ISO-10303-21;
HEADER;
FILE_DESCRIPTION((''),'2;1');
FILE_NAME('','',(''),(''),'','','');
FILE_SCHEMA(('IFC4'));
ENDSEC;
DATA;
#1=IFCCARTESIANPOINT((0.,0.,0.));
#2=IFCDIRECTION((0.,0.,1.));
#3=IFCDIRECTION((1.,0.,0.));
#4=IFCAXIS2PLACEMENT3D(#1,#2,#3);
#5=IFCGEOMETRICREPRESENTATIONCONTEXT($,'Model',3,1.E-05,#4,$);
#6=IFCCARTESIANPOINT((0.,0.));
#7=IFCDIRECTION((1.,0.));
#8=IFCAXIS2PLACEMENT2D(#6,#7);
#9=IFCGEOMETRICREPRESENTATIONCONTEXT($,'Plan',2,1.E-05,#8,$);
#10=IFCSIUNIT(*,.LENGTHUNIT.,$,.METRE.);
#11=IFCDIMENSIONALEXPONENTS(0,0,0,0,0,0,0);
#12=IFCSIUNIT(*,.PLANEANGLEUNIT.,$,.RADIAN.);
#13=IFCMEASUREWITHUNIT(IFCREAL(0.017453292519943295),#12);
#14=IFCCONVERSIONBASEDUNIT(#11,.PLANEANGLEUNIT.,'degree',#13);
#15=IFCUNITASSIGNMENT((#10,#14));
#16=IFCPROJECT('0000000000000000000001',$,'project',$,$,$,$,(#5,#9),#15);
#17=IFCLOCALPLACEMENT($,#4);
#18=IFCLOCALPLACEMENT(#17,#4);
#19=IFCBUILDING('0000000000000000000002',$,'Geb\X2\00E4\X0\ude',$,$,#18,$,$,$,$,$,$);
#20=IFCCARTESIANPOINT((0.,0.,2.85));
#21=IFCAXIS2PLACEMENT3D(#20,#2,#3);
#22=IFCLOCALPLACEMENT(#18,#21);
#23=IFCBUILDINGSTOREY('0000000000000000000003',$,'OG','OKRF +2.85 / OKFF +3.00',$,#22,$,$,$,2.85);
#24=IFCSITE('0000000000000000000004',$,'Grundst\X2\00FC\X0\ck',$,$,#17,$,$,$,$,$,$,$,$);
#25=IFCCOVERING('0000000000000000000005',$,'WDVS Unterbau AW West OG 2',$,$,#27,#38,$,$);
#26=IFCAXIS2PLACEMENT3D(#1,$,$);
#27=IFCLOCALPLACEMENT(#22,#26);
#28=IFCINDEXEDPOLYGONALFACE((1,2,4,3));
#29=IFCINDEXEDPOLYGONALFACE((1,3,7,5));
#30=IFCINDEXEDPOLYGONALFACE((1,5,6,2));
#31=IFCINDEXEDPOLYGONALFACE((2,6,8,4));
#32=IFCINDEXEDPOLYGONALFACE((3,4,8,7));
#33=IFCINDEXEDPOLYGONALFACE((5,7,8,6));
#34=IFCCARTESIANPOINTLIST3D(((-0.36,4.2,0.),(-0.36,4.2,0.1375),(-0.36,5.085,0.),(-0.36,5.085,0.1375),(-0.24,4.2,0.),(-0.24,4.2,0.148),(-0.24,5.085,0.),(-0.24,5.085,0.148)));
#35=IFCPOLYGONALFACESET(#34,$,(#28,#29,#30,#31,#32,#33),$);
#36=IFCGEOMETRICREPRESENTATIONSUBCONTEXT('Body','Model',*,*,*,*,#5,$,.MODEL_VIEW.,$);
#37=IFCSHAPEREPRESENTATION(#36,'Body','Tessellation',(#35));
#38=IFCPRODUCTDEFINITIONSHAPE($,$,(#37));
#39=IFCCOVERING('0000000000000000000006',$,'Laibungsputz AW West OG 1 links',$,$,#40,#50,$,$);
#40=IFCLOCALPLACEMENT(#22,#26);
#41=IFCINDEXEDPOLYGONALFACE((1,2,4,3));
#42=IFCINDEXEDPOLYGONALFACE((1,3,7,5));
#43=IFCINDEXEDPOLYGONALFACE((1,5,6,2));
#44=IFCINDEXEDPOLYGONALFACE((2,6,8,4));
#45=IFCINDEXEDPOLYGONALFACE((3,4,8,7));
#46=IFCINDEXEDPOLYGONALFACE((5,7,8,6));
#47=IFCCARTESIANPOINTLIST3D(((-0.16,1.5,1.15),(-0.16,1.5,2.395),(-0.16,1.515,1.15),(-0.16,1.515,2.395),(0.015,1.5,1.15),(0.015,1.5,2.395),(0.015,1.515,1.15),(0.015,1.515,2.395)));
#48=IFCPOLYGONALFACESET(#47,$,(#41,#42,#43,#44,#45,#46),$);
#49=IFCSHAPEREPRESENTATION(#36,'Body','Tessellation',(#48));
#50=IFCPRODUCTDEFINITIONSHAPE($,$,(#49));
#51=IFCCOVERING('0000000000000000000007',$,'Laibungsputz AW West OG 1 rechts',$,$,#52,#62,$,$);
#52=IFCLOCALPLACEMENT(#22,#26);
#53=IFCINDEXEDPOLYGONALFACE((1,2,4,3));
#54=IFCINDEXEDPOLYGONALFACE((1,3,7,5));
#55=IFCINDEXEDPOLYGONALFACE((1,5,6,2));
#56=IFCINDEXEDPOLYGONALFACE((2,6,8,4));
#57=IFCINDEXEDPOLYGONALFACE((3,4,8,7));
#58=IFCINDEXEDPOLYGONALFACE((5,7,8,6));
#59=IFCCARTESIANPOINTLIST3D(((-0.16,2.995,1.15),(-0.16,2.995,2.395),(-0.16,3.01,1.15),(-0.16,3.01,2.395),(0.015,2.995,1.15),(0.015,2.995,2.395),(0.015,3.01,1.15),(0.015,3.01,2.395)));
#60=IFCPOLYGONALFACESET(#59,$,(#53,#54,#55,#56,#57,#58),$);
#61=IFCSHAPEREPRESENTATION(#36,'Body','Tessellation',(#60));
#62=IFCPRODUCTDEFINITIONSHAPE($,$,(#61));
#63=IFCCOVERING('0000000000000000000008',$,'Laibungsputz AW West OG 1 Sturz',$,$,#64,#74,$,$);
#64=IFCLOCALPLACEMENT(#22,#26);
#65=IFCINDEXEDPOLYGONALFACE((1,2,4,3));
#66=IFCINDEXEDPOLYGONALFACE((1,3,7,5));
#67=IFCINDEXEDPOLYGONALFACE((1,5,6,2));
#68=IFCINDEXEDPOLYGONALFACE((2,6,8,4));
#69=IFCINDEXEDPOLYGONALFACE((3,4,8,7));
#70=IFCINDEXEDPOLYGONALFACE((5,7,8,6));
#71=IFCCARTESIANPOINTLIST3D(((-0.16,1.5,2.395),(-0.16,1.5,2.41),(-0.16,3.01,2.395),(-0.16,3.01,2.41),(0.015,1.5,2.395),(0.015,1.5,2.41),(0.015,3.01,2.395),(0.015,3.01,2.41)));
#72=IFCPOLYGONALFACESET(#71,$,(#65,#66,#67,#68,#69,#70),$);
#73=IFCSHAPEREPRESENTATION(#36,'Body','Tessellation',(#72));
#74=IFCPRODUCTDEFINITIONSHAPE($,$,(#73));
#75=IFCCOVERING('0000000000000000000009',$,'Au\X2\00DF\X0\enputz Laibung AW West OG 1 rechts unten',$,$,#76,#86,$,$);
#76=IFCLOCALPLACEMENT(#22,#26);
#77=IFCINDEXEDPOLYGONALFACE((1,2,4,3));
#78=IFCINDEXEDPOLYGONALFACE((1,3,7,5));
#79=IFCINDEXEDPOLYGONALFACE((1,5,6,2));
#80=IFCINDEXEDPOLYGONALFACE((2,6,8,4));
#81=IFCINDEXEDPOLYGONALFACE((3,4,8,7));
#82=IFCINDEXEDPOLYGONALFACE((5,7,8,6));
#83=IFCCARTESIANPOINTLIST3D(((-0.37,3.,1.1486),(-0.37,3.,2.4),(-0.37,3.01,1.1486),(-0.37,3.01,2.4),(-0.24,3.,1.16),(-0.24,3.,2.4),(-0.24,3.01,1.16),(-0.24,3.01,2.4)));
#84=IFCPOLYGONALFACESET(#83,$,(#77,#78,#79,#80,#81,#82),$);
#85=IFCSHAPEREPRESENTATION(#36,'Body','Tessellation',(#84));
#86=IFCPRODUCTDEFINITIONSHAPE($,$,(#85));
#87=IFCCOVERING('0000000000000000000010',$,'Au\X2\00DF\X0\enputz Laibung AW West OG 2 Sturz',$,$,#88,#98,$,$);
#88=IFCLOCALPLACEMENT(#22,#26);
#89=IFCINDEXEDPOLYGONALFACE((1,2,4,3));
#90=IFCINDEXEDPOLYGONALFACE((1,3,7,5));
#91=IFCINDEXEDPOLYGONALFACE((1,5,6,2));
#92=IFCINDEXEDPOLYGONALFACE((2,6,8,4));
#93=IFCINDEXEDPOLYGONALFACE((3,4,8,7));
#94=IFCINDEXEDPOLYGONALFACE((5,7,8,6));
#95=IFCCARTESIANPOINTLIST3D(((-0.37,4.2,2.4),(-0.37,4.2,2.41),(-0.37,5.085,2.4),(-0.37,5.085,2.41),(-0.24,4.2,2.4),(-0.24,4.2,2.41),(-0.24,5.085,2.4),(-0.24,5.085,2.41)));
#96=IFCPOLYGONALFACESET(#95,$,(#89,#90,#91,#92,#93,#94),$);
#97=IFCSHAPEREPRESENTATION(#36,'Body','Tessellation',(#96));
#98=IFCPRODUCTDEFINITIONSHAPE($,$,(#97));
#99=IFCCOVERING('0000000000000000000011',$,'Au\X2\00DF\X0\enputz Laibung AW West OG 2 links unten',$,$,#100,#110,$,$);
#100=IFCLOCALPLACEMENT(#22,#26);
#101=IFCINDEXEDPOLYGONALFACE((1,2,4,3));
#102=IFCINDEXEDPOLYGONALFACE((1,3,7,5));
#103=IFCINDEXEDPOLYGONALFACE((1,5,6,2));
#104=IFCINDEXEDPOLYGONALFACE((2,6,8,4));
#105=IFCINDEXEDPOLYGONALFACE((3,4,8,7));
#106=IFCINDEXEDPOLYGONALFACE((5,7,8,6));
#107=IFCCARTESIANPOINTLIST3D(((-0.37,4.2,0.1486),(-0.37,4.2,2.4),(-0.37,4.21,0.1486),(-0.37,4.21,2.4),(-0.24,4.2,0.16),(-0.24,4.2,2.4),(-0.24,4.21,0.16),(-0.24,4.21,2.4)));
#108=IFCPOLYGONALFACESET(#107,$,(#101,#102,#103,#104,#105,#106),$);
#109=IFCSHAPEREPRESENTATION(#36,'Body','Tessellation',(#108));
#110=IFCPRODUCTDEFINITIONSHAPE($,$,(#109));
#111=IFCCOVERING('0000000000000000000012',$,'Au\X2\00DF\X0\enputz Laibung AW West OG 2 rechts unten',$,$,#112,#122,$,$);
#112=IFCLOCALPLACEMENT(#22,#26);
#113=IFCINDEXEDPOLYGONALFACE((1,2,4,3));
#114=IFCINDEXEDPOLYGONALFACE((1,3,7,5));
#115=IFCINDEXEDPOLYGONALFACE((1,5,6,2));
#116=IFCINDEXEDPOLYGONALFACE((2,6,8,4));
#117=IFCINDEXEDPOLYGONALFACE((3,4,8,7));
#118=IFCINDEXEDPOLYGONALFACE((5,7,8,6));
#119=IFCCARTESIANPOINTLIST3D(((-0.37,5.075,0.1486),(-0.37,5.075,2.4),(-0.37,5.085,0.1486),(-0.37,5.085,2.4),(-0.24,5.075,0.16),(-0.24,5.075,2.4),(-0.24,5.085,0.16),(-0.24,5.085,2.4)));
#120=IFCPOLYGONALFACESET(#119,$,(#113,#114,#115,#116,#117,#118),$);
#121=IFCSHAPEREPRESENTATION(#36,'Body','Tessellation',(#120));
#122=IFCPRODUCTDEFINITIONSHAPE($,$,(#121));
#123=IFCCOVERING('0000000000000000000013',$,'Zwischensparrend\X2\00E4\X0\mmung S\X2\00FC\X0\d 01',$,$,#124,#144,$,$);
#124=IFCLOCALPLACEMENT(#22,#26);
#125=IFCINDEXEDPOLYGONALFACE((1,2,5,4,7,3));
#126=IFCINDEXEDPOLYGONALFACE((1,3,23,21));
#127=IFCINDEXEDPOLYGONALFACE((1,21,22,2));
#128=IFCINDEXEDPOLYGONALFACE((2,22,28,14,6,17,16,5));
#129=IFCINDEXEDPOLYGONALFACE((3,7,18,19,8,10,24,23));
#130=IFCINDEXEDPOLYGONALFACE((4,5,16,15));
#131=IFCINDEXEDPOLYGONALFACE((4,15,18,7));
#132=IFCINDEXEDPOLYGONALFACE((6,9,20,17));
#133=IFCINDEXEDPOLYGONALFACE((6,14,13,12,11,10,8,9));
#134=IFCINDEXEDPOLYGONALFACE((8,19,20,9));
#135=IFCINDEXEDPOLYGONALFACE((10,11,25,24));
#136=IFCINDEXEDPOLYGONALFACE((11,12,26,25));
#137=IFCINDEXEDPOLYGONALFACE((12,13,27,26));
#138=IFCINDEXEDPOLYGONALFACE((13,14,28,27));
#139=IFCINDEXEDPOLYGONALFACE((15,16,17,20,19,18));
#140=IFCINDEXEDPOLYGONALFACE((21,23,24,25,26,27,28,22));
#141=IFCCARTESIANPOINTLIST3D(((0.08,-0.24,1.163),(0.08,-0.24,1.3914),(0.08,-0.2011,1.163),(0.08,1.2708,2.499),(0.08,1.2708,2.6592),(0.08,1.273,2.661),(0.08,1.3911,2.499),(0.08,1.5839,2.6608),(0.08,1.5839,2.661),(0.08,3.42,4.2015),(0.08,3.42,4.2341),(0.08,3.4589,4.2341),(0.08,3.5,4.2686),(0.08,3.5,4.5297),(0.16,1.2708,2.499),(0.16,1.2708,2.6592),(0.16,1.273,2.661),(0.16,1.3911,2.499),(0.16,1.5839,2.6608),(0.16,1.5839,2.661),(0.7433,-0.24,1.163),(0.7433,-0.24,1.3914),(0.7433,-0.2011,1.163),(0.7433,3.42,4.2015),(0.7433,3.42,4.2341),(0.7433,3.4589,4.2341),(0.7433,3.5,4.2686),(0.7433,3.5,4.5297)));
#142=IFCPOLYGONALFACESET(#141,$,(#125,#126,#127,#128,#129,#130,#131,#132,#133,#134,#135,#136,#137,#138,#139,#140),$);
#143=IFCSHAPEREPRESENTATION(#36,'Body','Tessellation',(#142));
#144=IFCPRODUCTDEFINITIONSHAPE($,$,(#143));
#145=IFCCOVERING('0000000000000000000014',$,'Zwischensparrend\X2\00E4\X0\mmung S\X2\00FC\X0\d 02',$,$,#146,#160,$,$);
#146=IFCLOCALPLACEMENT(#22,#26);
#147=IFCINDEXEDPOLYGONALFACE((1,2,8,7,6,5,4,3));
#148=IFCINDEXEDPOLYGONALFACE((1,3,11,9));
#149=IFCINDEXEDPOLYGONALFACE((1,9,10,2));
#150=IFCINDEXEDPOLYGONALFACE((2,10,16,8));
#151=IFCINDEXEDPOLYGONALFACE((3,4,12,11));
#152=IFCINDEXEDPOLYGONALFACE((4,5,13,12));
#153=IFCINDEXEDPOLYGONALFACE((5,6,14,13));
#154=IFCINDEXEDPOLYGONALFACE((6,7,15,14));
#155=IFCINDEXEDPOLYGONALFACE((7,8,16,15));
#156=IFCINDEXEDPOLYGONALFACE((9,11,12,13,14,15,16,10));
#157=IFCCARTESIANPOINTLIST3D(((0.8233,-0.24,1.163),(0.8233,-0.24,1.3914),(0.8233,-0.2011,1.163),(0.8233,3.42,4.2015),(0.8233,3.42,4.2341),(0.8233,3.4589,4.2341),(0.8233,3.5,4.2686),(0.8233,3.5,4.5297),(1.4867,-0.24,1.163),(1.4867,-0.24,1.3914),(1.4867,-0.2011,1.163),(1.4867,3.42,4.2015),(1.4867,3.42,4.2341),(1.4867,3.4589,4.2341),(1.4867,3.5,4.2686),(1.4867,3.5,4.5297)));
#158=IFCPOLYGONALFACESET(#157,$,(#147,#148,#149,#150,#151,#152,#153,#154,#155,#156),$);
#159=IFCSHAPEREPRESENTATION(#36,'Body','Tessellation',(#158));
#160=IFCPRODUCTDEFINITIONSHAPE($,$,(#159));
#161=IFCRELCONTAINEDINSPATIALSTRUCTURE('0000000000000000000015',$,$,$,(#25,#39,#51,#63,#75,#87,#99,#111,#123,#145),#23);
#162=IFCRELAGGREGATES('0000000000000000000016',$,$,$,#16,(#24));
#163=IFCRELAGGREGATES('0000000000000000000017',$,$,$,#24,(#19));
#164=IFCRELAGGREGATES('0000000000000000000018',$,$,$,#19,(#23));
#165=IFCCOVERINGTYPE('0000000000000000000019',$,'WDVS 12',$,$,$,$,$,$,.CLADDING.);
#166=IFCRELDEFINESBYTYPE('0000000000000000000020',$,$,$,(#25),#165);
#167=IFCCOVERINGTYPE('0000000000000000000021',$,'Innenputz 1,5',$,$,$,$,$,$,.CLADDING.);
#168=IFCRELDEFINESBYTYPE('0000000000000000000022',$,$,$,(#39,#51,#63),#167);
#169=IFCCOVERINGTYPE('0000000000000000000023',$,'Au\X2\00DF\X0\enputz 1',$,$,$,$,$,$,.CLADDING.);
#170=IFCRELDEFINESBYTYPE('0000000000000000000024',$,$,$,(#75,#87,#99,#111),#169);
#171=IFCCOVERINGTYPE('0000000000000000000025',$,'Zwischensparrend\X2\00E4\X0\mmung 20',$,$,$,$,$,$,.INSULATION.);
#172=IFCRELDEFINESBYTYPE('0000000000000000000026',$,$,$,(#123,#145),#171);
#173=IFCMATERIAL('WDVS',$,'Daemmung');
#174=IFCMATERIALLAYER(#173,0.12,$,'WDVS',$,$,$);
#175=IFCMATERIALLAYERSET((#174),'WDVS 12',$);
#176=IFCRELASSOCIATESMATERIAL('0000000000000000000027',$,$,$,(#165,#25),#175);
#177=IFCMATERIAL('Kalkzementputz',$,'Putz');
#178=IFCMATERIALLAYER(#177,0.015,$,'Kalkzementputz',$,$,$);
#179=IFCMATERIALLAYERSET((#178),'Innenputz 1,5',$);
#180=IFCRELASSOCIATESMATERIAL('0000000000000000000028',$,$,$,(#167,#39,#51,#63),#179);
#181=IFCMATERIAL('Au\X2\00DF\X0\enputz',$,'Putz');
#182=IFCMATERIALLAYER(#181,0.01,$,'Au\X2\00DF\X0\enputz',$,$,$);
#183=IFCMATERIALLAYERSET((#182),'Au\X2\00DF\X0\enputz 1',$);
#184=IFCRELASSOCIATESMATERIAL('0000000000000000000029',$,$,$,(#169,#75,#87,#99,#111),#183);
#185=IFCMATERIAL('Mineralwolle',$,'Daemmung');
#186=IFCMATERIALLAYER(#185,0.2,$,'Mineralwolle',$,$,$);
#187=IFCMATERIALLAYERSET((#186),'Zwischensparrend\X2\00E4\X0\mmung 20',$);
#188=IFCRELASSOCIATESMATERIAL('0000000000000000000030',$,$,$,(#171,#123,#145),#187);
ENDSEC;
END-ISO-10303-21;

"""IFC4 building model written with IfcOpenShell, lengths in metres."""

from ifc_helpers import new_model, entity, si_unit, converted_unit, frame, origin_with_axes, origin_2d_with_axis, place, context, subcontext, project, spatial, polyline, outline, extrude, material, layer, layer_set, layer_usage, type_object, element, save


model = new_model("IFC4")

# Units and contexts
model_context = context("Model", 3, precision=1e-05, world=origin_with_axes())
plan_context = context("Plan", 2, precision=1e-05, world=origin_2d_with_axis())
body_context = subcontext(model_context, "Body", "Model", "MODEL_VIEW")
ifc_project = project(units=[si_unit("LENGTHUNIT", "METRE"), converted_unit("PLANEANGLEUNIT", "degree", entity("IfcReal", 0.017453292519943295), si_unit("PLANEANGLEUNIT", "RADIAN"), dimensions=[0, 0, 0, 0, 0, 0, 0])], contexts=[model_context, plan_context])

# Site, building, storey
site_placement = place(None, origin_with_axes())
site = spatial("IfcSite", under=ifc_project, at=site_placement, Name="Grundstück")
building_placement = place(site_placement, origin_with_axes())
building = spatial("IfcBuilding", under=site, at=building_placement, Name="Gebäude")
storey_placement = place(building_placement, frame((0.0, 0.0, 2.85), z_axis=(0.0, 0.0, 1.0), x_axis=(1.0, 0.0, 0.0)))
storey = spatial("IfcBuildingStorey", under=building, at=storey_placement, Name="OG", Description="OKRF +2.85 / OKFF +3.00", Elevation=2.85)

# Coverings
ifc_material_1 = material(Name="WDVS", Category="Daemmung")
ifc_layer_1 = layer(ifc_material_1, 0.12, Name="WDVS")
ifc_layer_set_1 = layer_set([ifc_layer_1], Name="WDVS 12")
ifc_layer_usage_1 = layer_usage(ifc_layer_set_1, "AXIS2", "POSITIVE", 0.24)
covering_type_1 = type_object("IfcCoveringType", Name="WDVS 12", PredefinedType="CLADDING", material=ifc_layer_set_1)
covering_1_placement = place(storey_placement, frame((0.0, 0.0, 0.0), z_axis=(0.0, 0.0, 1.0), x_axis=(0.0, 1.0, 0.0)))
element("IfcCovering", 1, at=covering_1_placement, inside=storey, type_object=covering_type_1, material=ifc_layer_usage_1, Name="WDVS Unterbau AW West OG 2", context=body_context, shape_type="SweptSolid", body=[
    extrude(outline(polyline([(0.24, 0.0), (0.36, 0.0), (0.36, 0.1375), (0.24, 0.148), (0.24, 0.0)])), frame((4.2, 0.0, 0.0), z_axis=(1.0, 0.0, 0.0), x_axis=(0.0, 1.0, 0.0)), (0.0, 0.0, 1.0), 0.885),
])
ifc_material_2 = material(Name="Kalkzementputz", Category="Putz")
ifc_layer_2 = layer(ifc_material_2, 0.015, Name="Kalkzementputz")
ifc_layer_set_2 = layer_set([ifc_layer_2], Name="Innenputz 1,5")
ifc_layer_usage_2 = layer_usage(ifc_layer_set_2, "AXIS1", "POSITIVE", 1.5)
covering_type_2 = type_object("IfcCoveringType", Name="Innenputz 1,5", PredefinedType="CLADDING", material=ifc_layer_set_2)
covering_2_placement = place(storey_placement, frame((0.0, 0.0, 0.0), z_axis=(0.0, 0.0, 1.0), x_axis=(0.0, 1.0, 0.0)))
element("IfcCovering", 2, at=covering_2_placement, inside=storey, type_object=covering_type_2, material=ifc_layer_usage_2, Name="Laibungsputz AW West OG 1 links", context=body_context, shape_type="SweptSolid", body=[
    extrude(outline(polyline([(-0.015, 1.15), (0.16, 1.15), (0.16, 2.395), (-0.015, 2.395), (-0.015, 1.15)])), frame((1.5, 0.0, 0.0), z_axis=(1.0, 0.0, 0.0), x_axis=(0.0, 1.0, 0.0)), (0.0, 0.0, 1.0), 0.015),
])
ifc_layer_usage_3 = layer_usage(ifc_layer_set_2, "AXIS1", "POSITIVE", 2.995)
covering_3_placement = place(storey_placement, frame((0.0, 0.0, 0.0), z_axis=(0.0, 0.0, 1.0), x_axis=(0.0, 1.0, 0.0)))
element("IfcCovering", 3, at=covering_3_placement, inside=storey, type_object=covering_type_2, material=ifc_layer_usage_3, Name="Laibungsputz AW West OG 1 rechts", context=body_context, shape_type="SweptSolid", body=[
    extrude(outline(polyline([(-0.015, 1.15), (0.16, 1.15), (0.16, 2.395), (-0.015, 2.395), (-0.015, 1.15)])), frame((2.995, 0.0, 0.0), z_axis=(1.0, 0.0, 0.0), x_axis=(0.0, 1.0, 0.0)), (0.0, 0.0, 1.0), 0.015),
])
ifc_layer_usage_4 = layer_usage(ifc_layer_set_2, "AXIS3", "POSITIVE", 2.395)
covering_4_placement = place(storey_placement, frame((0.0, 0.0, 0.0), z_axis=(0.0, 0.0, 1.0), x_axis=(0.0, 1.0, 0.0)))
element("IfcCovering", 4, at=covering_4_placement, inside=storey, type_object=covering_type_2, material=ifc_layer_usage_4, Name="Laibungsputz AW West OG 1 Sturz", context=body_context, shape_type="SweptSolid", body=[
    extrude(outline(polyline([(-0.015, 2.395), (0.16, 2.395), (0.16, 2.41), (-0.015, 2.41), (-0.015, 2.395)])), frame((1.5, 0.0, 0.0), z_axis=(1.0, 0.0, 0.0), x_axis=(0.0, 1.0, 0.0)), (0.0, 0.0, 1.0), 1.51),
])
ifc_material_3 = material(Name="Außenputz", Category="Putz")
ifc_layer_3 = layer(ifc_material_3, 0.01, Name="Außenputz")
ifc_layer_set_3 = layer_set([ifc_layer_3], Name="Außenputz 1")
ifc_layer_usage_5 = layer_usage(ifc_layer_set_3, "AXIS1", "POSITIVE", 3.0)
covering_type_3 = type_object("IfcCoveringType", Name="Außenputz 1", PredefinedType="CLADDING", material=ifc_layer_set_3)
covering_5_placement = place(storey_placement, frame((0.0, 0.0, 0.0), z_axis=(0.0, 0.0, 1.0), x_axis=(0.0, 1.0, 0.0)))
element("IfcCovering", 5, at=covering_5_placement, inside=storey, type_object=covering_type_3, material=ifc_layer_usage_5, Name="Außenputz Laibung AW West OG 1 rechts unten", context=body_context, shape_type="SweptSolid", body=[
    extrude(outline(polyline([(0.24, 1.16), (0.37, 1.1486), (0.37, 2.4), (0.24, 2.4), (0.24, 1.16)])), frame((3.0, 0.0, 0.0), z_axis=(1.0, 0.0, 0.0), x_axis=(0.0, 1.0, 0.0)), (0.0, 0.0, 1.0), 0.01),
])
ifc_layer_usage_6 = layer_usage(ifc_layer_set_3, "AXIS3", "POSITIVE", 2.4)
covering_6_placement = place(storey_placement, frame((0.0, 0.0, 0.0), z_axis=(0.0, 0.0, 1.0), x_axis=(0.0, 1.0, 0.0)))
element("IfcCovering", 6, at=covering_6_placement, inside=storey, type_object=covering_type_3, material=ifc_layer_usage_6, Name="Außenputz Laibung AW West OG 2 Sturz", context=body_context, shape_type="SweptSolid", body=[
    extrude(outline(polyline([(0.24, 2.4), (0.37, 2.4), (0.37, 2.41), (0.24, 2.41), (0.24, 2.4)])), frame((4.2, 0.0, 0.0), z_axis=(1.0, 0.0, 0.0), x_axis=(0.0, 1.0, 0.0)), (0.0, 0.0, 1.0), 0.885),
])
ifc_layer_usage_7 = layer_usage(ifc_layer_set_3, "AXIS1", "POSITIVE", 4.2)
covering_7_placement = place(storey_placement, frame((0.0, 0.0, 0.0), z_axis=(0.0, 0.0, 1.0), x_axis=(0.0, 1.0, 0.0)))
element("IfcCovering", 7, at=covering_7_placement, inside=storey, type_object=covering_type_3, material=ifc_layer_usage_7, Name="Außenputz Laibung AW West OG 2 links unten", context=body_context, shape_type="SweptSolid", body=[
    extrude(outline(polyline([(0.24, 0.16), (0.37, 0.1486), (0.37, 2.4), (0.24, 2.4), (0.24, 0.16)])), frame((4.2, 0.0, 0.0), z_axis=(1.0, 0.0, 0.0), x_axis=(0.0, 1.0, 0.0)), (0.0, 0.0, 1.0), 0.01),
])
ifc_layer_usage_8 = layer_usage(ifc_layer_set_3, "AXIS1", "POSITIVE", 5.075)
covering_8_placement = place(storey_placement, frame((0.0, 0.0, 0.0), z_axis=(0.0, 0.0, 1.0), x_axis=(0.0, 1.0, 0.0)))
element("IfcCovering", 8, at=covering_8_placement, inside=storey, type_object=covering_type_3, material=ifc_layer_usage_8, Name="Außenputz Laibung AW West OG 2 rechts unten", context=body_context, shape_type="SweptSolid", body=[
    extrude(outline(polyline([(0.24, 0.16), (0.37, 0.1486), (0.37, 2.4), (0.24, 2.4), (0.24, 0.16)])), frame((5.075, 0.0, 0.0), z_axis=(1.0, 0.0, 0.0), x_axis=(0.0, 1.0, 0.0)), (0.0, 0.0, 1.0), 0.01),
])

# Covering, opening
ifc_material_4 = material(Name="Mineralwolle", Category="Daemmung")
ifc_layer_4 = layer(ifc_material_4, 0.2, Name="Mineralwolle")
ifc_layer_set_4 = layer_set([ifc_layer_4], Name="Zwischensparrendämmung 20")
ifc_layer_usage_9 = layer_usage(ifc_layer_set_4, "AXIS3", "POSITIVE", 0.0)
covering_type_4 = type_object("IfcCoveringType", Name="Zwischensparrendämmung 20", PredefinedType="INSULATION", material=ifc_layer_set_4)
covering_9_placement = place(storey_placement, frame((0.08, -0.24, 1.1304), z_axis=(0.0, -0.642788, 0.766044), x_axis=(1.0, 0.0, 0.0)))
covering_9 = element("IfcCovering", 9, at=covering_9_placement, inside=storey, type_object=covering_type_4, material=ifc_layer_usage_9, Name="Zwischensparrendämmung Süd 01", context=body_context, shape_type="SweptSolid", body=[
    extrude(outline(polyline([(0.021, 0.025), (0.0508, 0.0), (4.7778, 0.0), (4.7988, 0.025), (4.8286, 0.0), (4.8822, 0.0), (5.05, 0.2), (0.1678, 0.2), (0.021, 0.025)])), frame((0.0, 0.0, 0.0), z_axis=(1.0, 0.0, 0.0), x_axis=(0.0, 1.0, 0.0)), (0.0, 0.0, 1.0), 0.6633),
])
opening_1_placement = place(covering_9_placement, frame((-0.08, -2.3747, -3.2034), z_axis=(0.0, 0.642788, 0.766044), x_axis=(1.0, 0.0, 0.0)))
element("IfcOpeningElement", 10, at=opening_1_placement, cuts=covering_9, PredefinedType="RECESS", context=body_context, shape_type="SweptSolid", body=[
    extrude(outline(polyline([(0.08, 1.2708), (0.16, 1.2708), (0.16, 1.5839), (0.08, 1.5839), (0.08, 1.2708)])), frame((0.0, 0.0, 5.349), z_axis=(0.0, 0.0, 1.0), x_axis=(1.0, 0.0, 0.0)), (0.0, 0.0, 1.0), 0.162),
])

# Covering
ifc_layer_usage_10 = layer_usage(ifc_layer_set_4, "AXIS3", "POSITIVE", 0.0)
covering_10_placement = place(storey_placement, frame((0.8233, -0.24, 1.1304), z_axis=(0.0, -0.642788, 0.766044), x_axis=(1.0, 0.0, 0.0)))
element("IfcCovering", 11, at=covering_10_placement, inside=storey, type_object=covering_type_4, material=ifc_layer_usage_10, Name="Zwischensparrendämmung Süd 02", context=body_context, shape_type="SweptSolid", body=[
    extrude(outline(polyline([(0.021, 0.025), (0.0508, 0.0), (4.7778, 0.0), (4.7988, 0.025), (4.8286, 0.0), (4.8822, 0.0), (5.05, 0.2), (0.1678, 0.2), (0.021, 0.025)])), frame((0.0, 0.0, 0.0), z_axis=(1.0, 0.0, 0.0), x_axis=(0.0, 1.0, 0.0)), (0.0, 0.0, 1.0), 0.6633),
])

save(model, "model.ifc")
